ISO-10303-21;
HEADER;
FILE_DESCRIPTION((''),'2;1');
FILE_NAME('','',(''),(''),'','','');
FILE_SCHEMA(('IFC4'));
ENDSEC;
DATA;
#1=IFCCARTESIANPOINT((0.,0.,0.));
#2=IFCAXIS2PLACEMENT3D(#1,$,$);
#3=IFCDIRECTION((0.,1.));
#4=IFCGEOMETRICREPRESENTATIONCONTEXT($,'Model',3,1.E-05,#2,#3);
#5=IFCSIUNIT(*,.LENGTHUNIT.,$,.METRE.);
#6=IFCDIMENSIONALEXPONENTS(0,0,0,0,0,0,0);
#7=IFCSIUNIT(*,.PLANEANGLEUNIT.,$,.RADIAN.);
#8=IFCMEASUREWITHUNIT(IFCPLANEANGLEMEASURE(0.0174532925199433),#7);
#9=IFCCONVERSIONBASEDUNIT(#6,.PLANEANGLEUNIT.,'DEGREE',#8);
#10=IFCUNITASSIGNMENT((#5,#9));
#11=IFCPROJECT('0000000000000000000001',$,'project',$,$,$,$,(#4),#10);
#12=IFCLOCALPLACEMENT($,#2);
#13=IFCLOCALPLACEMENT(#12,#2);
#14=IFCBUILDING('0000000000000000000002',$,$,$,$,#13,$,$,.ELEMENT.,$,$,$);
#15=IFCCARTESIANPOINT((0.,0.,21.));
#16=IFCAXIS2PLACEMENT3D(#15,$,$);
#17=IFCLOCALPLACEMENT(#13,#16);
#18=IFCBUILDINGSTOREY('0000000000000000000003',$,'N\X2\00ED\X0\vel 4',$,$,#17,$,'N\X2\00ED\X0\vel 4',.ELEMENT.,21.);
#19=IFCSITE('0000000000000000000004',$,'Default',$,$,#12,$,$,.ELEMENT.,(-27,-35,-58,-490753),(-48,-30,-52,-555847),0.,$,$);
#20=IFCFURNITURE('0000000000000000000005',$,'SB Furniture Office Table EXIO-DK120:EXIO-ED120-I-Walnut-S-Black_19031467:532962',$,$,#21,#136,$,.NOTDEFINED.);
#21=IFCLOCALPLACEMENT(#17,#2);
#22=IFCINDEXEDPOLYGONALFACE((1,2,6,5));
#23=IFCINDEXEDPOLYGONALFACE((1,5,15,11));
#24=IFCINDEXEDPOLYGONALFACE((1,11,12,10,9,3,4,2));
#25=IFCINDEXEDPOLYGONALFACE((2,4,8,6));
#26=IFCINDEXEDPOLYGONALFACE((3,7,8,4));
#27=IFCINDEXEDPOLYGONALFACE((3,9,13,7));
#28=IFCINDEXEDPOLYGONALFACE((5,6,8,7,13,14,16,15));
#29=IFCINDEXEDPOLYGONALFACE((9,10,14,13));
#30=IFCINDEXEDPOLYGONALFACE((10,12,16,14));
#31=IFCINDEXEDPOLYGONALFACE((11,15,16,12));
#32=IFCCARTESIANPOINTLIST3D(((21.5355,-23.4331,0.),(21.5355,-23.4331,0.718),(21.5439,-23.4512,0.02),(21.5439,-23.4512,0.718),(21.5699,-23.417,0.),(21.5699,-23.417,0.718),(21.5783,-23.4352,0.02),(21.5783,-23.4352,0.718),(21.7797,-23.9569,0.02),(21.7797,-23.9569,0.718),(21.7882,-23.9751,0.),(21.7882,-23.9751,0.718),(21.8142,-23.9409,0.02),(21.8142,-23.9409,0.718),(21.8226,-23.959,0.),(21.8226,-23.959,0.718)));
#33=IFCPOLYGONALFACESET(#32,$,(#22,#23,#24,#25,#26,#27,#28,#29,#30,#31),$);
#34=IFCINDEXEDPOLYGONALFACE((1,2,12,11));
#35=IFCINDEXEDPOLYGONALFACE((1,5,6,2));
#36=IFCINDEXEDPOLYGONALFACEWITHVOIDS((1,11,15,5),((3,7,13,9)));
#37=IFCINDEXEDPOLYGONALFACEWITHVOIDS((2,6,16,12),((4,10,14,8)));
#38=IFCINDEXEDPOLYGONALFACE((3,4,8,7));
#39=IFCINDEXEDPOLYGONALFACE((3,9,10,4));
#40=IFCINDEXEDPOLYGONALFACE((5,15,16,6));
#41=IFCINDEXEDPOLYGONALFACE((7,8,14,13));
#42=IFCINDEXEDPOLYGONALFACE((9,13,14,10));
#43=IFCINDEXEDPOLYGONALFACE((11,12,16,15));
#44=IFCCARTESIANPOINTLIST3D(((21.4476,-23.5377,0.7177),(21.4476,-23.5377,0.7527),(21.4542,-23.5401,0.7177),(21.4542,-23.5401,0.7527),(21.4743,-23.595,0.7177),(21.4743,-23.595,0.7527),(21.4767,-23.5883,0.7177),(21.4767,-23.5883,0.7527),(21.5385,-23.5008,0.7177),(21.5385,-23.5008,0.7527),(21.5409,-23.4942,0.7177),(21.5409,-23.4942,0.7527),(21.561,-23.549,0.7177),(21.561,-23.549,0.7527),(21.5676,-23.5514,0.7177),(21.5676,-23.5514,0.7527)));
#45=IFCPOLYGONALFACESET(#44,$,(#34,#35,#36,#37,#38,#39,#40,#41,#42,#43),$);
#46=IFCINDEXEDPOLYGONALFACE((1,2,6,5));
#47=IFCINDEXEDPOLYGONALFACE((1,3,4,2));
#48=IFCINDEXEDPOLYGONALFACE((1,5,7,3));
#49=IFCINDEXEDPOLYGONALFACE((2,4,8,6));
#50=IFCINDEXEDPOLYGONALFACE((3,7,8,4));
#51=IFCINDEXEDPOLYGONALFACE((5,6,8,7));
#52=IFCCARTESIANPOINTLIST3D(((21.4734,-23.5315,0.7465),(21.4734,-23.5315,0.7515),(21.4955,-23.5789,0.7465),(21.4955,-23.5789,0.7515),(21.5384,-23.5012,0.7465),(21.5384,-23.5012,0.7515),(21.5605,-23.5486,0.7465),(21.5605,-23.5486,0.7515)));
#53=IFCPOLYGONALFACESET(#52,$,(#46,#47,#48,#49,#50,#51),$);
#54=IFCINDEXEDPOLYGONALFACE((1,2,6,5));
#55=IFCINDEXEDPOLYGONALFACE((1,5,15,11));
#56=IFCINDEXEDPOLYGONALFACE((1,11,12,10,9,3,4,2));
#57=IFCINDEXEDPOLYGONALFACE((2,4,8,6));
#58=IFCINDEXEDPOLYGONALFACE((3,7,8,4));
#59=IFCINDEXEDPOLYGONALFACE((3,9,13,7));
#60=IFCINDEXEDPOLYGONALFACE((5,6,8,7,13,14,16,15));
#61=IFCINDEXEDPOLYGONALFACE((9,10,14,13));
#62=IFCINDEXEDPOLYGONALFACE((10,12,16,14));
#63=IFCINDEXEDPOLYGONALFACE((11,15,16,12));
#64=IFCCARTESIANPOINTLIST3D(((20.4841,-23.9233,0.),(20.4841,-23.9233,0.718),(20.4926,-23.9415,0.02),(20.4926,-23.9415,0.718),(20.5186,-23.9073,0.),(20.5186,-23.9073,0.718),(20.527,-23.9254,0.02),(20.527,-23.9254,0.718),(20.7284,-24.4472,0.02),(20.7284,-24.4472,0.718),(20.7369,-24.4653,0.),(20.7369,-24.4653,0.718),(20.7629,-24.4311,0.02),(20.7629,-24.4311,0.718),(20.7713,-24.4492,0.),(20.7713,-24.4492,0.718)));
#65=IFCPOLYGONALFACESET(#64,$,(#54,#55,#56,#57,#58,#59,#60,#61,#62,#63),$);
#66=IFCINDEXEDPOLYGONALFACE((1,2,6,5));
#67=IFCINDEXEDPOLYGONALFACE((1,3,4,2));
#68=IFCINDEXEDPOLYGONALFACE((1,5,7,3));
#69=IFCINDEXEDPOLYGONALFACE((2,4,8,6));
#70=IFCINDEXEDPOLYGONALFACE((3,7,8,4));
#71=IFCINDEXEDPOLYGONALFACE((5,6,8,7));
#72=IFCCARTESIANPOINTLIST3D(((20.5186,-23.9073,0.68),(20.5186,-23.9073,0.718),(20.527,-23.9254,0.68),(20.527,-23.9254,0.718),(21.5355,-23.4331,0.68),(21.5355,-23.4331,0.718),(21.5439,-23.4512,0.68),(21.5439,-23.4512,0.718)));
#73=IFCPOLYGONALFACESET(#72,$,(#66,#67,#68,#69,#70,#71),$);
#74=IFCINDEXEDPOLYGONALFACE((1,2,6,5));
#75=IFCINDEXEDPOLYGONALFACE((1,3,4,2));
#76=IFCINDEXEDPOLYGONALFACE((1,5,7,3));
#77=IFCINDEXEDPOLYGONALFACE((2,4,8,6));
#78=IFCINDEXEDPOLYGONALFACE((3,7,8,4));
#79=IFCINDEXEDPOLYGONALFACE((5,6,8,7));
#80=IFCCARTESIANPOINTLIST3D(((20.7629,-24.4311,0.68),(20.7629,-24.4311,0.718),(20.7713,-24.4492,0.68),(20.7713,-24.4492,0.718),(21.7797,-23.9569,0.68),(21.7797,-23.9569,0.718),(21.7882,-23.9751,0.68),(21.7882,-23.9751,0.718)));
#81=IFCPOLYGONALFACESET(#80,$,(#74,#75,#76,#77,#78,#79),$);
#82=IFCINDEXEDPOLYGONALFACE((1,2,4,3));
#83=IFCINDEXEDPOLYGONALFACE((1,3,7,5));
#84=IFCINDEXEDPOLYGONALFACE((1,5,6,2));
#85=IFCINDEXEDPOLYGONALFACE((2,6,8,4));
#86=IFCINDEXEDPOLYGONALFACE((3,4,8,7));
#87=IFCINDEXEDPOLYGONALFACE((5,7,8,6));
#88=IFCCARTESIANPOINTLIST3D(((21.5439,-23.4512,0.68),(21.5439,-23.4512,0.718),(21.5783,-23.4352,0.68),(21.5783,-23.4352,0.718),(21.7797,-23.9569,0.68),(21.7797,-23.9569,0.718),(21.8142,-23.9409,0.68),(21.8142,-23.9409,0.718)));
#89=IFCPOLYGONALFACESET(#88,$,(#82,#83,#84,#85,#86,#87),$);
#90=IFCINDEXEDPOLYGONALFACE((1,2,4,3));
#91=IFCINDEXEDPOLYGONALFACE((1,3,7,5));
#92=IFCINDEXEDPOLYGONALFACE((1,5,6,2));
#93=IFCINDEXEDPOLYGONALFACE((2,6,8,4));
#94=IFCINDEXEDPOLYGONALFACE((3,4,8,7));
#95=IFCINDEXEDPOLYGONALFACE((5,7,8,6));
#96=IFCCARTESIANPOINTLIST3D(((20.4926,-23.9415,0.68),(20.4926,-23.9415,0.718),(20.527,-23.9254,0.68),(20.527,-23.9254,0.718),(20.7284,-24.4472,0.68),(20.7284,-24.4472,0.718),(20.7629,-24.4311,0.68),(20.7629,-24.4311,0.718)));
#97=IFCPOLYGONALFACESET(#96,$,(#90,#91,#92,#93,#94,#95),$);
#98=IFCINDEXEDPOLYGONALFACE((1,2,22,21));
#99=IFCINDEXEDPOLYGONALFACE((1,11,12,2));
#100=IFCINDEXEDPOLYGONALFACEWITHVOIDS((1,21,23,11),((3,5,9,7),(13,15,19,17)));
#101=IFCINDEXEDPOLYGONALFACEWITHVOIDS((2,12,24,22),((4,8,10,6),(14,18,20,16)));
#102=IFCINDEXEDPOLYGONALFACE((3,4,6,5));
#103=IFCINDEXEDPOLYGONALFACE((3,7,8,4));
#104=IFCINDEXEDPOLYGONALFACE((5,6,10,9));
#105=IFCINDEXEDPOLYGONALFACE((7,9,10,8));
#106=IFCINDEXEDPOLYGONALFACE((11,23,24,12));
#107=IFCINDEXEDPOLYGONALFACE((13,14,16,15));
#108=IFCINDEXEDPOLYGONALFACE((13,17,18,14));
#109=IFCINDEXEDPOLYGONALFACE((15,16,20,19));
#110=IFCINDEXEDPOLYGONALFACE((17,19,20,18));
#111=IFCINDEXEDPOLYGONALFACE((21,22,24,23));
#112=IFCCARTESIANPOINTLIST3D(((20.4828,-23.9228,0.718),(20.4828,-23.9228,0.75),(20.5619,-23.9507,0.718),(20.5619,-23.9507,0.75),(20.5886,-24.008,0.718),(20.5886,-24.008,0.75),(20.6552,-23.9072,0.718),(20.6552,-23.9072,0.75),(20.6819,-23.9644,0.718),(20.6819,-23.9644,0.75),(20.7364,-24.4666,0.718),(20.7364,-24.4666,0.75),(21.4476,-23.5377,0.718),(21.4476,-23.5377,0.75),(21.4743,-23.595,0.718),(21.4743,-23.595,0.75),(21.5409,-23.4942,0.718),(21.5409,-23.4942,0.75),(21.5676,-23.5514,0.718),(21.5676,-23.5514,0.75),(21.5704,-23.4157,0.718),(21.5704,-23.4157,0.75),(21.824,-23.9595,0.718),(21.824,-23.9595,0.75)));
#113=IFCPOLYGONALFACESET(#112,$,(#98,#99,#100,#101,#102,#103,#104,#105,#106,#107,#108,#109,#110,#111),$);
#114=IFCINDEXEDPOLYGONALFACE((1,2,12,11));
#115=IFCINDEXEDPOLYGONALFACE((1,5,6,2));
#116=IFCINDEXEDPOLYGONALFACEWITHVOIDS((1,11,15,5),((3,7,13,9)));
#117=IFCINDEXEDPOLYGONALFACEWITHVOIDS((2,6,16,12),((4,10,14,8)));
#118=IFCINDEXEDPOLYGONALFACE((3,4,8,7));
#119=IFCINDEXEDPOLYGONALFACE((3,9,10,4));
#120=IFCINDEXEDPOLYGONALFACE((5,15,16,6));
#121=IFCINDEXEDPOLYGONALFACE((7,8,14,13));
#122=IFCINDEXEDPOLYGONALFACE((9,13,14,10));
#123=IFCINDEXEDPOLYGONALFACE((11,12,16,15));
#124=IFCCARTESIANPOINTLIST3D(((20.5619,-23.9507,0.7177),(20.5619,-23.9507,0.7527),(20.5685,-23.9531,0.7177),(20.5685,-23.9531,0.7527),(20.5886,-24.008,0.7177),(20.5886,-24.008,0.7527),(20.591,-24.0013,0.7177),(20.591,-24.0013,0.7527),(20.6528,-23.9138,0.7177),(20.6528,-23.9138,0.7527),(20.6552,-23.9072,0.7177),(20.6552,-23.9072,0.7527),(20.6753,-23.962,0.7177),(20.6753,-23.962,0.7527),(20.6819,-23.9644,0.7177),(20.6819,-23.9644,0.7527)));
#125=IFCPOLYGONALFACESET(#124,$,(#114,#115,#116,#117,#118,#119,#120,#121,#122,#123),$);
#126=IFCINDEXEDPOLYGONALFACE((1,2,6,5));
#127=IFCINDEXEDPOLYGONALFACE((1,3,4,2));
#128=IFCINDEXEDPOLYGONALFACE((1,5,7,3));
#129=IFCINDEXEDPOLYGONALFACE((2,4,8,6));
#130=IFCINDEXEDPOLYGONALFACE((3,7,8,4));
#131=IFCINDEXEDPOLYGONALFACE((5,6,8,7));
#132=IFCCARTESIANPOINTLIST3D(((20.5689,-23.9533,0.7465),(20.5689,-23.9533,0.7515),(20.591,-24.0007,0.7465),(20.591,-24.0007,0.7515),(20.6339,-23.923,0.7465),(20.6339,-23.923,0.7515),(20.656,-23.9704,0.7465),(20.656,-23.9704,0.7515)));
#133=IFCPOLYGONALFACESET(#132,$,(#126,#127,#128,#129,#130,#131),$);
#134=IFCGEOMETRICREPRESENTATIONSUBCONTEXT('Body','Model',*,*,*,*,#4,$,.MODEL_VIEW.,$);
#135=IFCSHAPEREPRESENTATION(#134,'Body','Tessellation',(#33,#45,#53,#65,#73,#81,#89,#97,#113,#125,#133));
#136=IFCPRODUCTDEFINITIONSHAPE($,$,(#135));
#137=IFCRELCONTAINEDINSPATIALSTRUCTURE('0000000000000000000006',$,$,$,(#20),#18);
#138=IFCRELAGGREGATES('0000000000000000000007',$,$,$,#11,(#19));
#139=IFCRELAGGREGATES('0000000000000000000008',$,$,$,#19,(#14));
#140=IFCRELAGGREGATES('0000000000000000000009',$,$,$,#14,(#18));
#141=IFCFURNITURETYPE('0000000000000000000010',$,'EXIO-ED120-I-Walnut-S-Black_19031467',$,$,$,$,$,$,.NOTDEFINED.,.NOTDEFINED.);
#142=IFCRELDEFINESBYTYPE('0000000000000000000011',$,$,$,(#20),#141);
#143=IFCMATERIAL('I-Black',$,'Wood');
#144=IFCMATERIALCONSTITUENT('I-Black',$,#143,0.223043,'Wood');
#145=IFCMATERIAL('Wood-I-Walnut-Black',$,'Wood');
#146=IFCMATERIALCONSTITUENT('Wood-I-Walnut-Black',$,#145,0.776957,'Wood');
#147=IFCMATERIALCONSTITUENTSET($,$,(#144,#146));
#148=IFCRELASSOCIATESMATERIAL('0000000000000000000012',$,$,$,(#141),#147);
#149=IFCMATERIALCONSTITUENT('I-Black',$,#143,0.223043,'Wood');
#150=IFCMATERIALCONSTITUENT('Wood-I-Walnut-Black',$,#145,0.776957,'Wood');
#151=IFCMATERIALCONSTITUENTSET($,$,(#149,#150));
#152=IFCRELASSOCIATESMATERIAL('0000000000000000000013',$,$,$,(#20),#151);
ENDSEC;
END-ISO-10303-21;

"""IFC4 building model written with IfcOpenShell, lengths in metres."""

from ifc_helpers import new_model, entity, si_unit, converted_unit, direction, frame, frame_2d, origin, origin_2d_with_axis, place, context, subcontext, project, spatial, polyline, rectangle, outline, extrude, source, transform, mapped, material, constituent, constituent_set, type_object, type_shapes, element, save


model = new_model("IFC4")

# Units and contexts
model_context = context("Model", 3, precision=1e-05, world=origin(), true_north=direction((0.0, 1.0)))
body_context = subcontext(model_context, "Body", "Model", "MODEL_VIEW")
ifc_project = project(units=[si_unit("LENGTHUNIT", "METRE"), converted_unit("PLANEANGLEUNIT", "DEGREE", entity("IfcPlaneAngleMeasure", 0.0174532925199433), si_unit("PLANEANGLEUNIT", "RADIAN"), dimensions=[0, 0, 0, 0, 0, 0, 0])], contexts=[model_context])

# Site, building, storey
site_placement = place(None, origin())
site = spatial("IfcSite", under=ifc_project, at=site_placement, Name="Default", CompositionType="ELEMENT", RefLatitude=(-27, -35, -58, -490753), RefLongitude=(-48, -30, -52, -555847), RefElevation=0.0)
building_placement = place(site_placement, origin())
building = spatial("IfcBuilding", under=site, at=building_placement, CompositionType="ELEMENT")
storey_placement = place(building_placement, frame((0.0, 0.0, 21.0)))
storey = spatial("IfcBuildingStorey", under=building, at=storey_placement, Name="Nível 4", LongName="Nível 4", CompositionType="ELEMENT", Elevation=21.0)

# Furniture
ifc_material_1 = material(Name="I-Black", Category="Wood")
ifc_material_2 = material(Name="Wood-I-Walnut-Black", Category="Wood")
ifc_constituent_1 = constituent(ifc_material_1, Name="I-Black", Category="Wood", fraction=0.223043)
ifc_constituent_2 = constituent(ifc_material_2, Name="Wood-I-Walnut-Black", Category="Wood", fraction=0.776957)
ifc_constituent_set_1 = constituent_set(constituents=[ifc_constituent_1, ifc_constituent_2])
furniture_type = type_object("IfcFurnitureType", Name="EXIO-ED120-I-Walnut-S-Black_19031467", AssemblyPlace="NOTDEFINED", PredefinedType="NOTDEFINED", material=ifc_constituent_set_1)
shared_shape_1 = source(origin(), body_context, "Body", "SweptSolid", [
    extrude(outline(polyline([(-0.354, -0.279), (-0.354, -0.299), (0.364, -0.299), (0.364, 0.299), (-0.354, 0.299), (-0.354, 0.279), (0.344, 0.279), (0.344, -0.279), (-0.354, -0.279)])), frame((0.561, 0.0, 0.364), z_axis=(-1.0, 0.0, 0.0), x_axis=(0.0, 0.0, -1.0)), (0.0, 0.0, -1.0), 0.038),
    extrude(outline(polyline([(-0.0316, -0.0515), (0.0316, -0.0515), (0.0316, 0.0515), (-0.0316, 0.0515), (-0.0316, -0.0515)]), holes=[polyline([(0.0266, -0.0465), (-0.0266, -0.0465), (-0.0266, 0.0465), (0.0266, 0.0465), (0.0266, -0.0465)])]), frame((0.4886, 0.2097, 0.7177), z_axis=(0.0, 0.0, 1.0), x_axis=(0.0, -1.0, 0.0)), (0.0, 0.0, 1.0), 0.035),
    extrude(rectangle(XDim=0.0717, YDim=0.0523, at=origin_2d_with_axis()), frame((0.499, 0.2099, 0.7465), z_axis=(0.0, 0.0, 1.0), x_axis=(-1.0, 0.0, 0.0)), (0.0, 0.0, 1.0), 0.005),
    extrude(outline(polyline([(-0.354, -0.279), (-0.354, -0.299), (0.364, -0.299), (0.364, 0.299), (-0.354, 0.299), (-0.354, 0.279), (0.344, 0.279), (0.344, -0.279), (-0.354, -0.279)])), frame((-0.599, 0.0, 0.364), z_axis=(-1.0, 0.0, 0.0), x_axis=(0.0, 0.0, -1.0)), (0.0, 0.0, -1.0), 0.038),
    extrude(rectangle(XDim=1.122, YDim=0.02, at=frame_2d((0.0, 0.0), x_axis=(1.0, 0.0))), frame((0.0, 0.289, 0.68), z_axis=(0.0, 0.0, 1.0), x_axis=(-1.0, 0.0, 0.0)), (0.0, 0.0, 1.0), 0.038),
    extrude(rectangle(XDim=1.122, YDim=0.02, at=origin_2d_with_axis()), frame((0.0, -0.289, 0.68), z_axis=(0.0, 0.0, 1.0), x_axis=(-1.0, 0.0, 0.0)), (0.0, 0.0, 1.0), 0.038),
    extrude(rectangle(XDim=0.038, YDim=0.558, at=frame_2d((0.0, 0.0), x_axis=(1.0, 0.0))), frame((0.58, 0.0, 0.68), z_axis=(0.0, 0.0, 1.0), x_axis=(-1.0, 0.0, 0.0)), (0.0, 0.0, 1.0), 0.038),
    extrude(rectangle(XDim=0.038, YDim=0.558, at=origin_2d_with_axis()), frame((-0.58, 0.0, 0.68), z_axis=(0.0, 0.0, 1.0), x_axis=(-1.0, 0.0, 0.0)), (0.0, 0.0, 1.0), 0.038),
    extrude(outline(polyline([(-0.6, -0.3), (0.6, -0.3), (0.6, 0.3), (-0.6, 0.3), (-0.6, -0.3)]), holes=[polyline([(0.4371, -0.2413), (0.4371, -0.1782), (0.5401, -0.1782), (0.5401, -0.2413), (0.4371, -0.2413)]), polyline([(-0.5401, -0.2413), (-0.5401, -0.1782), (-0.4371, -0.1782), (-0.4371, -0.2413), (-0.5401, -0.2413)])]), frame((0.0, 0.0, 0.718), z_axis=(0.0, 0.0, 1.0), x_axis=(-1.0, 0.0, 0.0)), (0.0, 0.0, 1.0), 0.032),
    extrude(outline(polyline([(-0.0316, -0.0515), (0.0316, -0.0515), (0.0316, 0.0515), (-0.0316, 0.0515), (-0.0316, -0.0515)]), holes=[polyline([(0.0266, -0.0465), (-0.0266, -0.0465), (-0.0266, 0.0465), (0.0266, 0.0465), (0.0266, -0.0465)])]), frame((-0.4886, 0.2097, 0.7177), z_axis=(0.0, 0.0, 1.0), x_axis=(0.0, 1.0, 0.0)), (0.0, 0.0, 1.0), 0.035),
    extrude(rectangle(XDim=0.0523, YDim=0.0717, at=origin_2d_with_axis()), frame((-0.499, 0.2099, 0.7465), z_axis=(0.0, 0.0, 1.0), x_axis=(0.0, -1.0, 0.0)), (0.0, 0.0, 1.0), 0.005),
])
type_shapes(furniture_type, [shared_shape_1])
ifc_constituent_3 = constituent(ifc_material_1, Name="I-Black", Category="Wood", fraction=0.223043)
ifc_constituent_4 = constituent(ifc_material_2, Name="Wood-I-Walnut-Black", Category="Wood", fraction=0.776957)
ifc_constituent_set_2 = constituent_set(constituents=[ifc_constituent_3, ifc_constituent_4])
furniture_1_placement = place(storey_placement, frame((21.1534, -23.9412, 0.0), z_axis=(0.0, 0.0, 1.0), x_axis=(0.906308, 0.422618, 0.0)))
element("IfcFurniture", 1, at=furniture_1_placement, inside=storey, type_object=furniture_type, material=ifc_constituent_set_2, Name="SB Furniture Office Table EXIO-DK120:EXIO-ED120-I-Walnut-S-Black_19031467:532962", PredefinedType="NOTDEFINED", context=body_context, shape_type="MappedRepresentation", body=[
    mapped(shared_shape_1, transform((0.0, 0.0, 0.0), scale=1.0)),
])

save(model, "model.ifc")
